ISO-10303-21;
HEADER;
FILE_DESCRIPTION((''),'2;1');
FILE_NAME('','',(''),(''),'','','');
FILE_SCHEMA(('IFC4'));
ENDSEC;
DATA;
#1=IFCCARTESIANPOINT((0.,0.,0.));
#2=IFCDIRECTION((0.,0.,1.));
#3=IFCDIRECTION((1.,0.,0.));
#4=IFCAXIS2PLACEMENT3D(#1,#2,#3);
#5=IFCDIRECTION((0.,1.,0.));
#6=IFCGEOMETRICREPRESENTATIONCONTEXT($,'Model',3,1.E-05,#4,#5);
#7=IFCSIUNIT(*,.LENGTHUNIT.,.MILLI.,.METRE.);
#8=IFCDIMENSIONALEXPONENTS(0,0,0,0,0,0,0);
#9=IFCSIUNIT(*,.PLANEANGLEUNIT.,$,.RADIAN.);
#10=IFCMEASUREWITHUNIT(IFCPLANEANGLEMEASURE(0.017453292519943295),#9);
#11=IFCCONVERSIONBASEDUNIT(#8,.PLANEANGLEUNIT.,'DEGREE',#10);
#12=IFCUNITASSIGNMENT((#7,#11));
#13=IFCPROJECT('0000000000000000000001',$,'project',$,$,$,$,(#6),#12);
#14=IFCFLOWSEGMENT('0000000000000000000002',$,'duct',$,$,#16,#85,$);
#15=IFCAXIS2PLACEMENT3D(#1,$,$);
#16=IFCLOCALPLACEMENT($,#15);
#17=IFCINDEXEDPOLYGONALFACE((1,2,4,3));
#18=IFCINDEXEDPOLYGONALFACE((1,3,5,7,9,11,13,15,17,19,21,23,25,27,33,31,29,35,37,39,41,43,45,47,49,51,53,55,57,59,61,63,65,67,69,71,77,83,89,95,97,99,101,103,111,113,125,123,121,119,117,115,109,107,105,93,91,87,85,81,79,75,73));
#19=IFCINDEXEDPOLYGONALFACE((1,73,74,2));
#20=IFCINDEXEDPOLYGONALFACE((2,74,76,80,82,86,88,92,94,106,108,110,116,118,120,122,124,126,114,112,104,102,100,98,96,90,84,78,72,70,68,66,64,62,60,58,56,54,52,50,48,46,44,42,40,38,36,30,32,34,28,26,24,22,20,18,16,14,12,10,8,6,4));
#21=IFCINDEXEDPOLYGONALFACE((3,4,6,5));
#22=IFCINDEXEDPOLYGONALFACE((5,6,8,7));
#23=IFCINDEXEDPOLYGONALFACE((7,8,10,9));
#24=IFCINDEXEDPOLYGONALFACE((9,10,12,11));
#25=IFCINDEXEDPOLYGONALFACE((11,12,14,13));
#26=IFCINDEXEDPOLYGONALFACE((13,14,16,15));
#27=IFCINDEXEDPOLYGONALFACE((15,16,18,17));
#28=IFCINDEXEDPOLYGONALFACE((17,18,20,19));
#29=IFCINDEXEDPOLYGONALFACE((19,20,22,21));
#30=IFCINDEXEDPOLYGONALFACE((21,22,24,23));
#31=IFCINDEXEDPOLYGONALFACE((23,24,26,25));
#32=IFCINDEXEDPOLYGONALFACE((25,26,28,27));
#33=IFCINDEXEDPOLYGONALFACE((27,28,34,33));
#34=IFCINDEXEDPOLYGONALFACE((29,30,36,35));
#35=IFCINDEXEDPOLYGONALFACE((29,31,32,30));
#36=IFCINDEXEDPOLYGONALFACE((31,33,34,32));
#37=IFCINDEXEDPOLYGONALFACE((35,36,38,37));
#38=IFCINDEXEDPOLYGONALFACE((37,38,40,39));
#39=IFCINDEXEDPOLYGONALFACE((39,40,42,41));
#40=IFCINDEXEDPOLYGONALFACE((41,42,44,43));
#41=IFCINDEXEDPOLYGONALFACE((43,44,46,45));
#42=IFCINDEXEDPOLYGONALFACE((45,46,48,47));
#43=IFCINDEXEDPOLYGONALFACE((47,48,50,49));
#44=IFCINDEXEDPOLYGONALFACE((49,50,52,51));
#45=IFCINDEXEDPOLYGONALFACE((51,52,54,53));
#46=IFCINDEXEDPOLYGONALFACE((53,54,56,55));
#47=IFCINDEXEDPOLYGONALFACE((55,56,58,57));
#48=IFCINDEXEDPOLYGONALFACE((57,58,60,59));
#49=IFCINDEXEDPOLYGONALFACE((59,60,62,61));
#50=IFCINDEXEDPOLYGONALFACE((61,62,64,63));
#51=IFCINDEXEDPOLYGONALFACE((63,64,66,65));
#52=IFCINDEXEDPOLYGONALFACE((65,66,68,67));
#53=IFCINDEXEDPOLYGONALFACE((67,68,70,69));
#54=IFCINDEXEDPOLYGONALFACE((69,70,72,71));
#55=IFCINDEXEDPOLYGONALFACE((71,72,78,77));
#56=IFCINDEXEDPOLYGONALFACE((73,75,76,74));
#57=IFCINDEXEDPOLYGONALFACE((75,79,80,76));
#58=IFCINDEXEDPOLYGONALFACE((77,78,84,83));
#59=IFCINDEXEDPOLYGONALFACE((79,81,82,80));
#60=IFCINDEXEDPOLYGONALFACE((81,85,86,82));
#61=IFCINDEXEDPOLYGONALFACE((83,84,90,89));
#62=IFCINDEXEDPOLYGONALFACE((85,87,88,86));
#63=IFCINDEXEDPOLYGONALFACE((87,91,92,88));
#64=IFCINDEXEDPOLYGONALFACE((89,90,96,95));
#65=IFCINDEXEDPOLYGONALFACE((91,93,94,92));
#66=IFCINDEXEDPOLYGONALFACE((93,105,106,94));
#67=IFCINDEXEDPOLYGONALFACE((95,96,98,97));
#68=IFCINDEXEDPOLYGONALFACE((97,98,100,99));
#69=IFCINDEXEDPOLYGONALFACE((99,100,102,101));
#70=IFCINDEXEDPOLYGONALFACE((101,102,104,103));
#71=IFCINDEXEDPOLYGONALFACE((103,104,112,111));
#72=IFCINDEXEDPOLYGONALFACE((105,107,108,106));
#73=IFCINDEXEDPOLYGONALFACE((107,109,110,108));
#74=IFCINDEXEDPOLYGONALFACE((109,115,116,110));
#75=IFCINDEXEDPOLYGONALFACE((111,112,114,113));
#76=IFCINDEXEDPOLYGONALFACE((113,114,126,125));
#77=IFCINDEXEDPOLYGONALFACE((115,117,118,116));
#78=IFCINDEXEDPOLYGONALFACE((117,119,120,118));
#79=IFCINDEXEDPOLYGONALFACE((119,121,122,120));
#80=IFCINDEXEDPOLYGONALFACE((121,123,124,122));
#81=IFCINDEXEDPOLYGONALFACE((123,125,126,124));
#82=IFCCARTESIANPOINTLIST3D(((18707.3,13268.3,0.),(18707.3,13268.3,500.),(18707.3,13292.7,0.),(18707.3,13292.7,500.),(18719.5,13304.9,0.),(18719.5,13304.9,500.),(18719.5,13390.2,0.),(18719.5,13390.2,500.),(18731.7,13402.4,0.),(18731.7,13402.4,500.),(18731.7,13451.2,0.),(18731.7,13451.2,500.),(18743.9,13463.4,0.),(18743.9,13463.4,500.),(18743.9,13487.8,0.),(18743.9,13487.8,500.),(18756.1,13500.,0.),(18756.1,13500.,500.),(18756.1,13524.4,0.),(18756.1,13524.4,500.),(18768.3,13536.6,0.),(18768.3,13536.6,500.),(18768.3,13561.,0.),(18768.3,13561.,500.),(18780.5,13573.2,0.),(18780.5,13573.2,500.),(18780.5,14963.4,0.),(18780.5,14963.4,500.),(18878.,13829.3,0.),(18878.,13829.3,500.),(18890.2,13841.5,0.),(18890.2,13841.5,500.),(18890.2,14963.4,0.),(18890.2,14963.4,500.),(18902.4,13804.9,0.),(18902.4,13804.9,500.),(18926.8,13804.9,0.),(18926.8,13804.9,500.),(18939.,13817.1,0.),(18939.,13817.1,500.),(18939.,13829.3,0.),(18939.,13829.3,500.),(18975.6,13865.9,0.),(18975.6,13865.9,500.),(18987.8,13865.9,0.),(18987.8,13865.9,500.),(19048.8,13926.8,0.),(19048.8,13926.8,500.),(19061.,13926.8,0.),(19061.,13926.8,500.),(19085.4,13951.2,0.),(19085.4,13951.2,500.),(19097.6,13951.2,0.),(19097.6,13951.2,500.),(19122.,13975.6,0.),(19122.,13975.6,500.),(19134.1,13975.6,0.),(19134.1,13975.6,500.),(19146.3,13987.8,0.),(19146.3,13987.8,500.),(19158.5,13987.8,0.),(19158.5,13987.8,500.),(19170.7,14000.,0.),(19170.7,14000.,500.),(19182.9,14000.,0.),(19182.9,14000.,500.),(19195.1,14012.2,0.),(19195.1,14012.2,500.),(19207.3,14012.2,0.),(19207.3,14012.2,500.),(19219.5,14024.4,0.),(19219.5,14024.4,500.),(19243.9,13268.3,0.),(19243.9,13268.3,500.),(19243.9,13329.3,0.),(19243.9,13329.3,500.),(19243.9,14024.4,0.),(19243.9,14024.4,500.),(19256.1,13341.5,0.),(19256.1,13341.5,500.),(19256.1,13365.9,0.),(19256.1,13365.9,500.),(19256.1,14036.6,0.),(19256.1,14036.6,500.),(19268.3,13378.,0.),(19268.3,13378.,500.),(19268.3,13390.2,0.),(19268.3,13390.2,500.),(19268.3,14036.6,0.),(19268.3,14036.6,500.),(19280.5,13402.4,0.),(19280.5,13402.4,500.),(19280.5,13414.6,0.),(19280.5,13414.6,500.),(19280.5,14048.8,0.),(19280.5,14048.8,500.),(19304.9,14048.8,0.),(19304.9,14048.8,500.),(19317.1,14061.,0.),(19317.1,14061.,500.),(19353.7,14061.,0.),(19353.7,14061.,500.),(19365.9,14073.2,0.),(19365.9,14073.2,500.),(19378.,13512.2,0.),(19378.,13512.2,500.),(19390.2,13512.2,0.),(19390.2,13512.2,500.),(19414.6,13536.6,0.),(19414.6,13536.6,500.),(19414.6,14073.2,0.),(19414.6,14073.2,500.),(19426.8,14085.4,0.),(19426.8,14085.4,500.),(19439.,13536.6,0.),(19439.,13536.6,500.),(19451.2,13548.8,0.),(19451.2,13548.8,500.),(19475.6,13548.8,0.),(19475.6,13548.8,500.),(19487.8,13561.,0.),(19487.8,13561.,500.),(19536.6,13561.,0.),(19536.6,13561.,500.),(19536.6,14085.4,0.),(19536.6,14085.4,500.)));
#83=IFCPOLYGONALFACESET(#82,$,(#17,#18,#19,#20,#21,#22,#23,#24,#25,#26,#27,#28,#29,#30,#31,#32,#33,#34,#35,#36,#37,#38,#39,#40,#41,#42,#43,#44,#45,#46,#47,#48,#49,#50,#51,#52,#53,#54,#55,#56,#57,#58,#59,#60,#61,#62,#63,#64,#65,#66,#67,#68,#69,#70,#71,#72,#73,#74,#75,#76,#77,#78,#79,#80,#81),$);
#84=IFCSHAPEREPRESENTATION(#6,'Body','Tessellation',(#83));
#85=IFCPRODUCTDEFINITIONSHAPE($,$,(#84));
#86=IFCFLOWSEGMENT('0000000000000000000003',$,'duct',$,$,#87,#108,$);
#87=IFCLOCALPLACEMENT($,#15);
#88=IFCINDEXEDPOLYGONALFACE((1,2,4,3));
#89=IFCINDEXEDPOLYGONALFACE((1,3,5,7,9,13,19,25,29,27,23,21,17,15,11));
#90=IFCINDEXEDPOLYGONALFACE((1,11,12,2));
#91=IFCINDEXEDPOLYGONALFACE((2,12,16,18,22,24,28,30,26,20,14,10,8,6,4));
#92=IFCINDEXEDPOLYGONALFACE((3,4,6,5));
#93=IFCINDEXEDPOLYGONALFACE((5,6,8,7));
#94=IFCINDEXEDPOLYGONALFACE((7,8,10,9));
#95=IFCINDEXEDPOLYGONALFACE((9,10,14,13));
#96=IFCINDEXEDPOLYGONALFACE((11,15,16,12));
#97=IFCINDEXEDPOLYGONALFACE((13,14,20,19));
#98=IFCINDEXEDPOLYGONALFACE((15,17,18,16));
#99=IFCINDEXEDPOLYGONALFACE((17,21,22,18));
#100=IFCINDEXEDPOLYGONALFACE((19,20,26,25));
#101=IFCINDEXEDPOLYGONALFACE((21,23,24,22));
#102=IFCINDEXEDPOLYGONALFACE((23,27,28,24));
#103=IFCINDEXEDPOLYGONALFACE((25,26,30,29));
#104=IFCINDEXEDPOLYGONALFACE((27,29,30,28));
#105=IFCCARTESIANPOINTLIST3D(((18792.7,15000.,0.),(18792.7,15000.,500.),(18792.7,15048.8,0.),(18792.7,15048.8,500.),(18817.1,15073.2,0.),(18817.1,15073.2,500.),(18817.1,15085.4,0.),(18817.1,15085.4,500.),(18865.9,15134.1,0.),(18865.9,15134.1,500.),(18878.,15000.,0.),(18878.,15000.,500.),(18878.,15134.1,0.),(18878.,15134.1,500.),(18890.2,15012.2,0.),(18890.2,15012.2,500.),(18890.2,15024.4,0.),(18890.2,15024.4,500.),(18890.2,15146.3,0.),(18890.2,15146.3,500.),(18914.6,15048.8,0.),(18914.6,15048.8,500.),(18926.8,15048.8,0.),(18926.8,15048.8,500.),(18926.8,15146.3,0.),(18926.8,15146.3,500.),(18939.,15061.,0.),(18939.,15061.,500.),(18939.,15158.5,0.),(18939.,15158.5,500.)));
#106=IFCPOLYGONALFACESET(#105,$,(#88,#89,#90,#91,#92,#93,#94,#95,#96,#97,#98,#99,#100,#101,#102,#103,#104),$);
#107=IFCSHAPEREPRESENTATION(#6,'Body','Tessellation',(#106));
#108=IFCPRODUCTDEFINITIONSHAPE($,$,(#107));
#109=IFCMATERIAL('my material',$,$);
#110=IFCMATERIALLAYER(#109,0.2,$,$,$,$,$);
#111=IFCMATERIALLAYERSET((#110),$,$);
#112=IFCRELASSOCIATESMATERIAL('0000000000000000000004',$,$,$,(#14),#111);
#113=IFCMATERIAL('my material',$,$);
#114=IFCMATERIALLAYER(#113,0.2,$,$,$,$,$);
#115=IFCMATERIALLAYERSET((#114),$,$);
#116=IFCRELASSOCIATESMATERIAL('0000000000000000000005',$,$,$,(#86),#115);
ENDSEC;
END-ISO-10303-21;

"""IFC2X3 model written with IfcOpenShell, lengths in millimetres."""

from ifc_helpers import new_model, entity, si_unit, converted_unit, direction, origin_with_axes, place, context, project, polyline, outline, extrude, material, layer, layer_set, layer_usage, element, save


model = new_model("IFC2X3")

# Units and contexts
model_context = context("Model", 3, precision=1e-05, world=origin_with_axes(), true_north=direction((0.0, 1.0, 0.0)))
ifc_project = project(units=[si_unit("LENGTHUNIT", "METRE", prefix="MILLI"), converted_unit("PLANEANGLEUNIT", "DEGREE", entity("IfcPlaneAngleMeasure", 0.017453292519943295), si_unit("PLANEANGLEUNIT", "RADIAN"), dimensions=[0, 0, 0, 0, 0, 0, 0])], contexts=[model_context])

# Flow segments
ifc_material_1 = material(Name="my material")
ifc_layer_1 = layer(ifc_material_1, 0.2)
ifc_layer_set_1 = layer_set([ifc_layer_1])
ifc_layer_usage_1 = layer_usage(ifc_layer_set_1, "AXIS2", "POSITIVE", -0.1)
flow_segment_1_placement = place(None, origin_with_axes())
element("IfcFlowSegment", 1, at=flow_segment_1_placement, material=ifc_layer_usage_1, Name="duct", context=model_context, shape_type="SweptSolid", body=[
    extrude(outline(polyline([(18707.3, 13268.3), (19243.9, 13268.3), (19243.9, 13329.3), (19256.1, 13341.5), (19256.1, 13365.9), (19268.3, 13378.0), (19268.3, 13390.2), (19280.5, 13402.4), (19280.5, 13414.6), (19378.0, 13512.2), (19390.2, 13512.2), (19414.6, 13536.6), (19439.0, 13536.6), (19451.2, 13548.8), (19475.6, 13548.8), (19487.8, 13561.0), (19536.6, 13561.0), (19536.6, 14085.4), (19426.8, 14085.4), (19414.6, 14073.2), (19365.9, 14073.2), (19353.7, 14061.0), (19317.1, 14061.0), (19304.9, 14048.8), (19280.5, 14048.8), (19268.3, 14036.6), (19256.1, 14036.6), (19243.9, 14024.4), (19219.5, 14024.4), (19207.3, 14012.2), (19195.1, 14012.2), (19182.9, 14000.0), (19170.7, 14000.0), (19158.5, 13987.8), (19146.3, 13987.8), (19134.1, 13975.6), (19122.0, 13975.6), (19097.6, 13951.2), (19085.4, 13951.2), (19061.0, 13926.8), (19048.8, 13926.8), (18987.8, 13865.9), (18975.6, 13865.9), (18939.0, 13829.3), (18939.0, 13817.1), (18926.8, 13804.9), (18902.4, 13804.9), (18878.0, 13829.3), (18890.2, 13841.5), (18890.2, 14963.4), (18780.5, 14963.4), (18780.5, 13573.2), (18768.3, 13561.0), (18768.3, 13536.6), (18756.1, 13524.4), (18756.1, 13500.0), (18743.9, 13487.8), (18743.9, 13463.4), (18731.7, 13451.2), (18731.7, 13402.4), (18719.5, 13390.2), (18719.5, 13304.9), (18707.3, 13292.7), (18707.3, 13268.3)])), origin_with_axes(), (0.0, 0.0, 1.0), 500.0),
])
ifc_material_2 = material(Name="my material")
ifc_layer_2 = layer(ifc_material_2, 0.2)
ifc_layer_set_2 = layer_set([ifc_layer_2])
ifc_layer_usage_2 = layer_usage(ifc_layer_set_2, "AXIS2", "POSITIVE", -0.1)
flow_segment_2_placement = place(None, origin_with_axes())
element("IfcFlowSegment", 2, at=flow_segment_2_placement, material=ifc_layer_usage_2, Name="duct", context=model_context, shape_type="SweptSolid", body=[
    extrude(outline(polyline([(18792.7, 15000.0), (18878.0, 15000.0), (18890.2, 15012.2), (18890.2, 15024.4), (18914.6, 15048.8), (18926.8, 15048.8), (18939.0, 15061.0), (18939.0, 15158.5), (18926.8, 15146.3), (18890.2, 15146.3), (18878.0, 15134.1), (18865.9, 15134.1), (18817.1, 15085.4), (18817.1, 15073.2), (18792.7, 15048.8), (18792.7, 15000.0)])), origin_with_axes(), (0.0, 0.0, 1.0), 500.0),
])

save(model, "model.ifc")
